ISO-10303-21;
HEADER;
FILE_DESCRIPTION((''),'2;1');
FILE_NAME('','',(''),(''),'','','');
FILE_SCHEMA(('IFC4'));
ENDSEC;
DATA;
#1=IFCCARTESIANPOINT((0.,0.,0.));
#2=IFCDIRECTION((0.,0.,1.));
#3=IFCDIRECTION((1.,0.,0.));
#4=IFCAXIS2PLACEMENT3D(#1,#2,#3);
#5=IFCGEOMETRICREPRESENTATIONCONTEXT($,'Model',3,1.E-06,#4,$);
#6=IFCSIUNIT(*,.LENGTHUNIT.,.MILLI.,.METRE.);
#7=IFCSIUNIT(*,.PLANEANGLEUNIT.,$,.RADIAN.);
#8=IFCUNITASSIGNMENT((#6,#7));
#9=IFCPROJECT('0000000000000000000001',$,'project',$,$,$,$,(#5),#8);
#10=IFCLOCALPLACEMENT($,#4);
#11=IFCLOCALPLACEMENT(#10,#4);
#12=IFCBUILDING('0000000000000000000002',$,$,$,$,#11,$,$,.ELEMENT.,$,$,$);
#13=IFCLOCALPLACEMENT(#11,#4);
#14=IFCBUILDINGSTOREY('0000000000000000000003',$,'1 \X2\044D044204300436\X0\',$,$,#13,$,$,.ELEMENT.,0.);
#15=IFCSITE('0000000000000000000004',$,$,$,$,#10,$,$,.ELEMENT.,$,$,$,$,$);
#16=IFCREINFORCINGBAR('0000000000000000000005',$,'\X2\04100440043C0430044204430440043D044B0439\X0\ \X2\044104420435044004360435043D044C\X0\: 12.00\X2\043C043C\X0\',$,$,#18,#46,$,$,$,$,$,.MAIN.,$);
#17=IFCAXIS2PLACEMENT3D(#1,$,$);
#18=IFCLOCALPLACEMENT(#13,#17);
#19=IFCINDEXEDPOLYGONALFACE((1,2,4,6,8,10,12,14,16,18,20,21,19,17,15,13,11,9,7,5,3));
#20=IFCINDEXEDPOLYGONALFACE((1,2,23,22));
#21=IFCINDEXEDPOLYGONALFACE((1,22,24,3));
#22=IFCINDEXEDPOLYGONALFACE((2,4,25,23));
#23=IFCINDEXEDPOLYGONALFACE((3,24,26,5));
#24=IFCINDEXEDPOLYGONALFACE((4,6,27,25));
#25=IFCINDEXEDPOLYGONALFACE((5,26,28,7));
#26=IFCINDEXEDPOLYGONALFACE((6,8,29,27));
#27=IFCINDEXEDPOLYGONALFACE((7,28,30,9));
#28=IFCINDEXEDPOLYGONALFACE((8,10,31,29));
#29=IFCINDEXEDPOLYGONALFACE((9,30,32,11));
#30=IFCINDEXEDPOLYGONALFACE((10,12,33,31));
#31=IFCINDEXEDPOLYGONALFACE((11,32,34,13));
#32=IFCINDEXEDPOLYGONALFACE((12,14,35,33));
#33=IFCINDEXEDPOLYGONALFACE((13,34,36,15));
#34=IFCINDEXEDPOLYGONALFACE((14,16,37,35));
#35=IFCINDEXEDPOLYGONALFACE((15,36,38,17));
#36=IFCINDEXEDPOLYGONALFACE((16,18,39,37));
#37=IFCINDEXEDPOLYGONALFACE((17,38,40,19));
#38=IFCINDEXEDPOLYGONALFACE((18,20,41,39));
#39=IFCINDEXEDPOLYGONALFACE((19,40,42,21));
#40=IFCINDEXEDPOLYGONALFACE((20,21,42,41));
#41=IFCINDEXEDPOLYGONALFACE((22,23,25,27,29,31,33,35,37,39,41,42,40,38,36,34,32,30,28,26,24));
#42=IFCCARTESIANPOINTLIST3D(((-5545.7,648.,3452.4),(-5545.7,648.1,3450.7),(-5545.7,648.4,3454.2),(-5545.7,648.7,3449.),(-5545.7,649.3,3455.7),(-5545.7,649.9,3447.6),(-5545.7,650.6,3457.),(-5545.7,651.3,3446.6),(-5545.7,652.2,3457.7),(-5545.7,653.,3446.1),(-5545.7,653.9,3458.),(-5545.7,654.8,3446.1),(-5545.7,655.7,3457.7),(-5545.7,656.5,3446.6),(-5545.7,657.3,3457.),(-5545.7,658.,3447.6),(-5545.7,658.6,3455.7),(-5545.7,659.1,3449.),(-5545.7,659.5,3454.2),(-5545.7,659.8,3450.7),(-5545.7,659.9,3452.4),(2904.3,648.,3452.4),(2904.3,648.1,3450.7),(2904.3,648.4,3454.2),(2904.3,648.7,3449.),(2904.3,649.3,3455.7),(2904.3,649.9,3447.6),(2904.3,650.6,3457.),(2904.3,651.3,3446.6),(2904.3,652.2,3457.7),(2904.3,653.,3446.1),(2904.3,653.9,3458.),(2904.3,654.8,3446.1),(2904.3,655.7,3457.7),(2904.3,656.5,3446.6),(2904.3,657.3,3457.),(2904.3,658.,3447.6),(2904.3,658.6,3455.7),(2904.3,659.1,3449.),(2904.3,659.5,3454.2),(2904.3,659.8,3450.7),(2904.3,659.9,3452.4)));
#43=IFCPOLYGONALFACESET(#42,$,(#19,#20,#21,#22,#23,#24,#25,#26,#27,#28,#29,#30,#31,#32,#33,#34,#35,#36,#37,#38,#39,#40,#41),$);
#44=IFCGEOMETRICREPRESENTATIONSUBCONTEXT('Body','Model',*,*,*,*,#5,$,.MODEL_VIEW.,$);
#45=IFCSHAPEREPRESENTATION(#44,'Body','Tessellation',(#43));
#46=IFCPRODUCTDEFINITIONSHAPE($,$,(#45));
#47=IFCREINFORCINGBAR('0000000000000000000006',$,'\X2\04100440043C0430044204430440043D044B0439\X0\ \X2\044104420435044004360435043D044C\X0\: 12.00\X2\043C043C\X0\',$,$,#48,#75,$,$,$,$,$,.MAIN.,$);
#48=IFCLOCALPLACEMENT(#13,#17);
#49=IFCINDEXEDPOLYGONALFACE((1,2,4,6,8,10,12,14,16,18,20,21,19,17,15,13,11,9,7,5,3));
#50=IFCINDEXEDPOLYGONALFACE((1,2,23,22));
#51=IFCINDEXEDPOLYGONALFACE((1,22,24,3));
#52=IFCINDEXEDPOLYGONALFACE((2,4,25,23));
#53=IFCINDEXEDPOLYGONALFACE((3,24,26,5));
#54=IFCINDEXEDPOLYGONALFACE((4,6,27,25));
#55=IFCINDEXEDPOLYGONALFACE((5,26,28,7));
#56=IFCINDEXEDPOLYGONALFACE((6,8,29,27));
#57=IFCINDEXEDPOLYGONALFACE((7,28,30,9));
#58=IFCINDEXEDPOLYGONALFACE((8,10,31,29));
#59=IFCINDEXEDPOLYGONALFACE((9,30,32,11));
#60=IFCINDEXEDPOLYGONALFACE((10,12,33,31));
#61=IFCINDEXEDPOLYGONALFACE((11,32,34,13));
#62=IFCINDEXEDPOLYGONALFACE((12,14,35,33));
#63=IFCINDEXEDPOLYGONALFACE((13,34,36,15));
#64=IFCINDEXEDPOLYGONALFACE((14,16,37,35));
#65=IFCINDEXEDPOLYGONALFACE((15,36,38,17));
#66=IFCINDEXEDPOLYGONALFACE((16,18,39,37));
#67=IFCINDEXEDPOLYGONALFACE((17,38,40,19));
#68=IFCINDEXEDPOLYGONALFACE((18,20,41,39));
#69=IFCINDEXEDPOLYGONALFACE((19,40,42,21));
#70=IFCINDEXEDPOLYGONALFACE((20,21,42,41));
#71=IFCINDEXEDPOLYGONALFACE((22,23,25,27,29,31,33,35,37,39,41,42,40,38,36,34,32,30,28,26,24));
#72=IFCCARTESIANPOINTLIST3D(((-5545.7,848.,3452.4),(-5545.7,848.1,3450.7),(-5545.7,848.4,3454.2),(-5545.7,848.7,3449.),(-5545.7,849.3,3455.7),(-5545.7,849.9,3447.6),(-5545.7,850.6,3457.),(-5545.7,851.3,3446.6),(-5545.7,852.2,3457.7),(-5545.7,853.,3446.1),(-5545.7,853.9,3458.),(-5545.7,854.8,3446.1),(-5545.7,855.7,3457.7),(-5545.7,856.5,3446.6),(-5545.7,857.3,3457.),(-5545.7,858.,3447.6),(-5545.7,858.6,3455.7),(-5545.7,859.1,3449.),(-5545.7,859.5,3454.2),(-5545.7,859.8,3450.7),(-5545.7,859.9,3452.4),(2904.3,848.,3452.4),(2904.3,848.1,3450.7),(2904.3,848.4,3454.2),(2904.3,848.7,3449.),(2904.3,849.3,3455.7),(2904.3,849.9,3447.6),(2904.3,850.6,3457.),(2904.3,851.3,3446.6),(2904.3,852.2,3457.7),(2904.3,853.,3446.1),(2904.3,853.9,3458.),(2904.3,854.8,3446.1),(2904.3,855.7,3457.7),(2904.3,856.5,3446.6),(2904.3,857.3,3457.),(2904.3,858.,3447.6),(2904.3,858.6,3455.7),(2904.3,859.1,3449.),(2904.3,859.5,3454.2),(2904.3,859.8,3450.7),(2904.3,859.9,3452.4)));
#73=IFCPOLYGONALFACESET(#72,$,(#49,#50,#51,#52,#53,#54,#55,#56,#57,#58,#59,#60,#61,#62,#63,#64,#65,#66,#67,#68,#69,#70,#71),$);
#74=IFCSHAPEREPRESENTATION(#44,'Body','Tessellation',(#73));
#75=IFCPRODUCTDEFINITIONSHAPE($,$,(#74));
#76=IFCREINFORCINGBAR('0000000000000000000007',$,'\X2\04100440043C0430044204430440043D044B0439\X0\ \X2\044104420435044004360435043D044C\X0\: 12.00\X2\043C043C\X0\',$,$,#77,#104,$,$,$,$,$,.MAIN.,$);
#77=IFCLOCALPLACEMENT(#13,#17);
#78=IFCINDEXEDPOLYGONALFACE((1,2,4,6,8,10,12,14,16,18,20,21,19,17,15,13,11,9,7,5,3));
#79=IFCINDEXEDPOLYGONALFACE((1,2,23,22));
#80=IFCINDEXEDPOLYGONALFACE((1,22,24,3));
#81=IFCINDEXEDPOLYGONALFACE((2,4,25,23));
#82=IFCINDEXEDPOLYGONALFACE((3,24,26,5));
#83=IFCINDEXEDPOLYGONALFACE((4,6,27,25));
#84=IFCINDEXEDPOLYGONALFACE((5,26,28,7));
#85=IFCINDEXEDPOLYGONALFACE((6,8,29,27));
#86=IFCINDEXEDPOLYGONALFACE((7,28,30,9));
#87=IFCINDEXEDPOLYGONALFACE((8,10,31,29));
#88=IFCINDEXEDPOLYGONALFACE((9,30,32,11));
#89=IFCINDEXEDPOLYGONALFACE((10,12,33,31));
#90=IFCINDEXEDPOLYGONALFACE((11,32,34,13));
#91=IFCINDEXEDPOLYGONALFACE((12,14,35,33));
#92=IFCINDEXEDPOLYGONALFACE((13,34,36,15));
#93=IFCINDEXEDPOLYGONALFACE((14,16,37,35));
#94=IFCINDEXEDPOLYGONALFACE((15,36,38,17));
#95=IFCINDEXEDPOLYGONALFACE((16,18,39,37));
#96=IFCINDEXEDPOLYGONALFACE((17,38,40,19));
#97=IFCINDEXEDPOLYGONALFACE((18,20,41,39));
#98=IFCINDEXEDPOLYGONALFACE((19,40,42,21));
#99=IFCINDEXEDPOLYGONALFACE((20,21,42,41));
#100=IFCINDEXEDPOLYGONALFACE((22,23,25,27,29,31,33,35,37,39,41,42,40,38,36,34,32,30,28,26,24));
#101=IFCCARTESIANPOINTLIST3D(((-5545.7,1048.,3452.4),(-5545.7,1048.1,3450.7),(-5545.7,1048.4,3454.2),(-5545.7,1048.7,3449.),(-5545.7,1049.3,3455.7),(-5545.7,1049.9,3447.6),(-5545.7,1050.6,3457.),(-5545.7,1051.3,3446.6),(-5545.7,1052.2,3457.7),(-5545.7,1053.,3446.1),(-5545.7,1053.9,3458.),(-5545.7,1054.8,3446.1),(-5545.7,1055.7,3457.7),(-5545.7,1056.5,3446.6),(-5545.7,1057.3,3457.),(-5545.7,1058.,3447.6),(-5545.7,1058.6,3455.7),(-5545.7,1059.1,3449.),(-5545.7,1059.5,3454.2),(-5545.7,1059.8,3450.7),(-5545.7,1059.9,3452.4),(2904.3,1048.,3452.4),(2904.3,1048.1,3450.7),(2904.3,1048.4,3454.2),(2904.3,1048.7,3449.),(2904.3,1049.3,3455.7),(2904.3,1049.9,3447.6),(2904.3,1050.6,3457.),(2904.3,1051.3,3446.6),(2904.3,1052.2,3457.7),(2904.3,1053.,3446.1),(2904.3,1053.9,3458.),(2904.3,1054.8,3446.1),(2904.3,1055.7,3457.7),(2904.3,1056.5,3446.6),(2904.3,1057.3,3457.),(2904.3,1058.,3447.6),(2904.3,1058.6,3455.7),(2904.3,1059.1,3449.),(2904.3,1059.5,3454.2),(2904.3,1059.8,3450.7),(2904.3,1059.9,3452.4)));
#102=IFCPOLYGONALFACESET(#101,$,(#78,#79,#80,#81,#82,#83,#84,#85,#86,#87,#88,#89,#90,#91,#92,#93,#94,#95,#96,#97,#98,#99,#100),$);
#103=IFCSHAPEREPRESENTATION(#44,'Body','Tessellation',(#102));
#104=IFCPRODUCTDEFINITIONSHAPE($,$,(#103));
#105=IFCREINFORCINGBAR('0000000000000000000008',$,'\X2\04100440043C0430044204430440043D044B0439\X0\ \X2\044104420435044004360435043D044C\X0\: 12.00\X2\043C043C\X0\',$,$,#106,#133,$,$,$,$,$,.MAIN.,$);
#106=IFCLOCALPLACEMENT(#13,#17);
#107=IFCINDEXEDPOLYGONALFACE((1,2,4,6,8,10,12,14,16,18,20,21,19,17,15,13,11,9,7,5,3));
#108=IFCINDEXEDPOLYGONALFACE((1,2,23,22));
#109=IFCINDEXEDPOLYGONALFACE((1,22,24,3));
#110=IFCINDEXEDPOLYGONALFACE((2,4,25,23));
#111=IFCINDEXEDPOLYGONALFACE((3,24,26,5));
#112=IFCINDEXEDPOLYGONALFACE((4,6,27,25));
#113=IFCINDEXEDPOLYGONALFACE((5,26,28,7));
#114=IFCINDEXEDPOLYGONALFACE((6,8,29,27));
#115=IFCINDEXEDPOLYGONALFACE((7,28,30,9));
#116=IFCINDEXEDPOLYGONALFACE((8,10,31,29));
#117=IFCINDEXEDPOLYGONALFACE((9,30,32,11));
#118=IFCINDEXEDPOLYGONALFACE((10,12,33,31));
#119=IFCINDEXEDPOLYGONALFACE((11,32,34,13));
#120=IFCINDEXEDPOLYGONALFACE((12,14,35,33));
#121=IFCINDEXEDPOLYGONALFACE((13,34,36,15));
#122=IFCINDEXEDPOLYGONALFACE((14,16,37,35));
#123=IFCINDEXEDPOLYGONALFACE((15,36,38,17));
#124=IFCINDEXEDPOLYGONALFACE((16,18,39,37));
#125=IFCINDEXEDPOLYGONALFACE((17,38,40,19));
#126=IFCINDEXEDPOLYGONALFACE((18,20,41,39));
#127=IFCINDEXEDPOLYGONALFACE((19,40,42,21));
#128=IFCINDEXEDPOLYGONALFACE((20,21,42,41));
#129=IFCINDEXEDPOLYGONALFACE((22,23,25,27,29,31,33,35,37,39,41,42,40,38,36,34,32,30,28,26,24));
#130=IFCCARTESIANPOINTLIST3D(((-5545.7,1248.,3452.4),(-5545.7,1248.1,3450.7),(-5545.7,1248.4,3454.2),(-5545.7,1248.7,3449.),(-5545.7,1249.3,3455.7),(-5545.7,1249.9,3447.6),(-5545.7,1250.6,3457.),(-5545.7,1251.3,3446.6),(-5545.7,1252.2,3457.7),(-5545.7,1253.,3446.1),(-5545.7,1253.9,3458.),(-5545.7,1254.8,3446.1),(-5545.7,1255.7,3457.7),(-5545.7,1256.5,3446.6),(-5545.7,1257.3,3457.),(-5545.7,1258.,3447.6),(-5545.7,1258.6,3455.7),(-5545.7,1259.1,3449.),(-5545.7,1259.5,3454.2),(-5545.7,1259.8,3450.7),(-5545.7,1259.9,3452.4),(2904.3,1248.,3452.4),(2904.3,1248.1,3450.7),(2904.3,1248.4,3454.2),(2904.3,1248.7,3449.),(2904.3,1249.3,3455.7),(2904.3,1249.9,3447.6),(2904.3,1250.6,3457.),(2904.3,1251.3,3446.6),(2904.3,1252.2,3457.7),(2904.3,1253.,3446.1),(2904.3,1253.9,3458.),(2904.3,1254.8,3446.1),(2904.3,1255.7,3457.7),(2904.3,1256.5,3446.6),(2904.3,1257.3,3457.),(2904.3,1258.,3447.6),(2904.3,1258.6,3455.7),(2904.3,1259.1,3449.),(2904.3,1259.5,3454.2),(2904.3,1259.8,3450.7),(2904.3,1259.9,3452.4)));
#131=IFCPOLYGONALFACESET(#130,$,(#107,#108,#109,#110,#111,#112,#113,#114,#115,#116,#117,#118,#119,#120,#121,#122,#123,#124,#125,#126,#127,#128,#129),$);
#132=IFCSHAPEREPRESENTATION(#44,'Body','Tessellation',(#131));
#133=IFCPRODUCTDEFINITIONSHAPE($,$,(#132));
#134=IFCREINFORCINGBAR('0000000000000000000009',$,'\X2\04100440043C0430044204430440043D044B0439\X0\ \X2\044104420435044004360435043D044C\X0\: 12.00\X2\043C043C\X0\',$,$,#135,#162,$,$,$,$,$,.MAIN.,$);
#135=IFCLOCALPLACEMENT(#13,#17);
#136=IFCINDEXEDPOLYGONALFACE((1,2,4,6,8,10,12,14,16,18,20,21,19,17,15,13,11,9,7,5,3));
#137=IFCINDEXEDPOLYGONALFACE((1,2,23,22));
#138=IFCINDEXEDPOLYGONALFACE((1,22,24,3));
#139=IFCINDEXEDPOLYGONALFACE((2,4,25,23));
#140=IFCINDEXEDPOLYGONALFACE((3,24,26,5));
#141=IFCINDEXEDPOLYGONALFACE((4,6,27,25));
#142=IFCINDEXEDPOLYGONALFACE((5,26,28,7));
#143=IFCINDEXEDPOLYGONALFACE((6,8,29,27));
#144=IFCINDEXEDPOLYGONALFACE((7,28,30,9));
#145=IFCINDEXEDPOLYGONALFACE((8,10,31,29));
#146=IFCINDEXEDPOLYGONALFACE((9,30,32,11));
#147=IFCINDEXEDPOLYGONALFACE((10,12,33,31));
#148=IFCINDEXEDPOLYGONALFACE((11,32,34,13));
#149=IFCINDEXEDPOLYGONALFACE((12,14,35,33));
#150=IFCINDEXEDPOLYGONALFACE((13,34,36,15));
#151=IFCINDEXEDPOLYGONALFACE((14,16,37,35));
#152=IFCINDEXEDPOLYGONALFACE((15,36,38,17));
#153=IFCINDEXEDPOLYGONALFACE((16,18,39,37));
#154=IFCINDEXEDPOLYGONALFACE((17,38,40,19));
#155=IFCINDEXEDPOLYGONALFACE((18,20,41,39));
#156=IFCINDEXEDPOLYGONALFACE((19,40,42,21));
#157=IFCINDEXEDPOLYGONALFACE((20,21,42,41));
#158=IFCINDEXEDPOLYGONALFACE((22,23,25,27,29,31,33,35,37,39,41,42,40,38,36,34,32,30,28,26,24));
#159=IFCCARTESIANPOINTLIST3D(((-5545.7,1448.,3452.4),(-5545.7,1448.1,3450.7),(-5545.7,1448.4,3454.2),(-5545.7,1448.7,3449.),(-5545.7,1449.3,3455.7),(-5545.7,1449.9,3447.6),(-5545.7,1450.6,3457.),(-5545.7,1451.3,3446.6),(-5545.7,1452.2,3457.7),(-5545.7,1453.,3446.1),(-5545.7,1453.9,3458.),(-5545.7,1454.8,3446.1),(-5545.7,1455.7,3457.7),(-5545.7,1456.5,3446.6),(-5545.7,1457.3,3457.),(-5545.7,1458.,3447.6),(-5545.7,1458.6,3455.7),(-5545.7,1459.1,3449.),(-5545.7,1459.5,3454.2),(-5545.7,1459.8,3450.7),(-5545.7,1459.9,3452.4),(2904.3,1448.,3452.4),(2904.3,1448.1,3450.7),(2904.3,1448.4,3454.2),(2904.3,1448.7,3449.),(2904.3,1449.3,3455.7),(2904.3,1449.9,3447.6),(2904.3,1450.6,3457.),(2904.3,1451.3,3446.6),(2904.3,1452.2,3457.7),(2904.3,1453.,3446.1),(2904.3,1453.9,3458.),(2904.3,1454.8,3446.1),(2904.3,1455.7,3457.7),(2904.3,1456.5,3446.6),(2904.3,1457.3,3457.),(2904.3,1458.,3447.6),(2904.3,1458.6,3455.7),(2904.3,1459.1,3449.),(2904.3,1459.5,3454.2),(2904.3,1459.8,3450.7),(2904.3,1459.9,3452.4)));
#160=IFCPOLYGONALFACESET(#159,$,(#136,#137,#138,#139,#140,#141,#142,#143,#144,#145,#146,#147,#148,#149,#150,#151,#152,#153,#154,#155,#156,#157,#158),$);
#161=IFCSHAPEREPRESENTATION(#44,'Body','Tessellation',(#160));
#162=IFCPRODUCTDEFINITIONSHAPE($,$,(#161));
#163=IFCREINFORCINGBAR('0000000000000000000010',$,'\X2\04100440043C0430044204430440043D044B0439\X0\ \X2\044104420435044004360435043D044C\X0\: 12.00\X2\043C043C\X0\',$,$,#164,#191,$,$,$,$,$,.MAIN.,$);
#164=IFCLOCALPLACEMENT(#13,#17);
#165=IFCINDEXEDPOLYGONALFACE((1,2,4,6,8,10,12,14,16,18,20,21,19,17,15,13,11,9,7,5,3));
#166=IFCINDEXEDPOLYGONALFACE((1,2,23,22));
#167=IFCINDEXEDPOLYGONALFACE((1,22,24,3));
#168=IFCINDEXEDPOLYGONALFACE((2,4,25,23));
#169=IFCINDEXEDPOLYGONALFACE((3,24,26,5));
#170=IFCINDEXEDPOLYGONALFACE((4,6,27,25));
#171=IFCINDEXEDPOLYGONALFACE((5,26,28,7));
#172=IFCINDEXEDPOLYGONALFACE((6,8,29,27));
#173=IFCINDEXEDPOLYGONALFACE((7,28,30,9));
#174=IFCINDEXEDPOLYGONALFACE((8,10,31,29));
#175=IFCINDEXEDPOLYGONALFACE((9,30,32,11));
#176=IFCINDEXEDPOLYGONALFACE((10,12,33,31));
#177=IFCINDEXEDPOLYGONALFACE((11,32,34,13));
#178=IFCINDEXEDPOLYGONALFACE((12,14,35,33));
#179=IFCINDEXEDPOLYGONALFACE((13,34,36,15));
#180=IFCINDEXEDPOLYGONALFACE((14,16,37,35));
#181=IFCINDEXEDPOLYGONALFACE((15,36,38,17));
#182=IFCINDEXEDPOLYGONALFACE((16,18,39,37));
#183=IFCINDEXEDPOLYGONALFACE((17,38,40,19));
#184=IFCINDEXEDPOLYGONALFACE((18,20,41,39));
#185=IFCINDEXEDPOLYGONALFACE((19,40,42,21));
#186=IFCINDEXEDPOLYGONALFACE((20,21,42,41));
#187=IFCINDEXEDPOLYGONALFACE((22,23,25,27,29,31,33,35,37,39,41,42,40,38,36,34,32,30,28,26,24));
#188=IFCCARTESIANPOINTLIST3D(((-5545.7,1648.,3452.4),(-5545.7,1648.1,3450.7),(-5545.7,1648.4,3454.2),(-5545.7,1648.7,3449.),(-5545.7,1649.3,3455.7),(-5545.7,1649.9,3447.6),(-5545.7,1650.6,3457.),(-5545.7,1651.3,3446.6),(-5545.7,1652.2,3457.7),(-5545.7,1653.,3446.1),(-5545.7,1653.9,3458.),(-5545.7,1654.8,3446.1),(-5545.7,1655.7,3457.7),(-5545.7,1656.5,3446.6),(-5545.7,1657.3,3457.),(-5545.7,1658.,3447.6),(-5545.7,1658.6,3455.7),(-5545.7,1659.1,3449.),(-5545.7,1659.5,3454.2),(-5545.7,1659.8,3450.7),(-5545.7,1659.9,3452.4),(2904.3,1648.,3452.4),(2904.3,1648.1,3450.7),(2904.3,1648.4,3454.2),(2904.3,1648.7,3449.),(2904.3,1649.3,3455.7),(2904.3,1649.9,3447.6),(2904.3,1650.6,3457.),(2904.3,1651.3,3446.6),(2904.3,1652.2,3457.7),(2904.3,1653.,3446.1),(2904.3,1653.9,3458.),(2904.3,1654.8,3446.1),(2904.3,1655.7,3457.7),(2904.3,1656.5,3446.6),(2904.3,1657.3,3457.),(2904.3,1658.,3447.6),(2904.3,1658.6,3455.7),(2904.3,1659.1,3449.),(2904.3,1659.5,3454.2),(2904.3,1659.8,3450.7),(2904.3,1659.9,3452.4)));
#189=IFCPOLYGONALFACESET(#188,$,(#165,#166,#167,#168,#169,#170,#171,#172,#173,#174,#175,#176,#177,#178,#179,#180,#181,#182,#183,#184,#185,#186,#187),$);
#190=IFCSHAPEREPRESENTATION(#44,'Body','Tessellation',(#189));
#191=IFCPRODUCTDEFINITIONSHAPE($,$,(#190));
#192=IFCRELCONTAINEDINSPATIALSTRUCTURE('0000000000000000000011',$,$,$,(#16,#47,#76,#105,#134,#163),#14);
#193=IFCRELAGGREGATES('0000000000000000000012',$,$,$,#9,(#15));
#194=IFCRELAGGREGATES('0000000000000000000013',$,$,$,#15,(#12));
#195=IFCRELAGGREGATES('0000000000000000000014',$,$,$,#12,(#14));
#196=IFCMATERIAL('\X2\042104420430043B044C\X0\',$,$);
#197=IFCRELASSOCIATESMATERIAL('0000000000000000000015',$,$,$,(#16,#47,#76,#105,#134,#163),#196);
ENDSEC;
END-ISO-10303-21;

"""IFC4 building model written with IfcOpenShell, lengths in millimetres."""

from ifc_helpers import new_model, entity, si_unit, origin_with_axes, place, context, subcontext, project, spatial, source, transform, mapped, material, element, save


model = new_model("IFC4")

# Units and contexts
model_context = context("Model", 3, precision=1e-06, world=origin_with_axes())
body_context = subcontext(model_context, "Body", "Model", "MODEL_VIEW")
ifc_project = project(units=[si_unit("LENGTHUNIT", "METRE", prefix="MILLI"), si_unit("PLANEANGLEUNIT", "RADIAN")], contexts=[model_context])

# Site, building, storey
site_placement = place(None, origin_with_axes())
site = spatial("IfcSite", under=ifc_project, at=site_placement, CompositionType="ELEMENT")
building_placement = place(site_placement, origin_with_axes())
building = spatial("IfcBuilding", under=site, at=building_placement, CompositionType="ELEMENT")
storey_placement = place(building_placement, origin_with_axes())
storey = spatial("IfcBuildingStorey", under=building, at=storey_placement, Name="1 этаж", CompositionType="ELEMENT", Elevation=0.0)

# Reinforcing bars
ifc_material_1 = material(Name="Сталь")
shared_shape_1 = source(origin_with_axes(), body_context, "Body", "AdvancedSweptSolid", [
    entity("IfcSweptDiskSolid", entity("IfcIndexedPolyCurve", entity("IfcCartesianPointList3D", [[0.0, 0.0, 0.0], [8450.0, 0.0, 0.0]]), [entity("IfcLineIndex", [1, 2])]), 6.0),
])
reinforcing_bar_1_placement = place(storey_placement, origin_with_axes())
element("IfcReinforcingBar", 1, at=reinforcing_bar_1_placement, inside=storey, material=ifc_material_1, Name="Арматурный стержень: 12.00мм", PredefinedType="MAIN", context=body_context, shape_type="MappedRepresentation", body=[
    mapped(shared_shape_1, transform((-5545.7, 653.9, 3452.0), x_axis=(1.0, 0.0, 0.0), y_axis=(0.0, 1.0, 0.0), z_axis=(0.0, 0.0, 1.0), scale=1.0)),
])
reinforcing_bar_2_placement = place(storey_placement, origin_with_axes())
element("IfcReinforcingBar", 2, at=reinforcing_bar_2_placement, inside=storey, material=ifc_material_1, Name="Арматурный стержень: 12.00мм", PredefinedType="MAIN", context=body_context, shape_type="MappedRepresentation", body=[
    mapped(shared_shape_1, transform((-5545.7, 853.9, 3452.0), x_axis=(1.0, 0.0, 0.0), y_axis=(0.0, 1.0, 0.0), z_axis=(0.0, 0.0, 1.0), scale=1.0)),
])
reinforcing_bar_3_placement = place(storey_placement, origin_with_axes())
element("IfcReinforcingBar", 3, at=reinforcing_bar_3_placement, inside=storey, material=ifc_material_1, Name="Арматурный стержень: 12.00мм", PredefinedType="MAIN", context=body_context, shape_type="MappedRepresentation", body=[
    mapped(shared_shape_1, transform((-5545.7, 1053.9, 3452.0), x_axis=(1.0, 0.0, 0.0), y_axis=(0.0, 1.0, 0.0), z_axis=(0.0, 0.0, 1.0), scale=1.0)),
])
reinforcing_bar_4_placement = place(storey_placement, origin_with_axes())
element("IfcReinforcingBar", 4, at=reinforcing_bar_4_placement, inside=storey, material=ifc_material_1, Name="Арматурный стержень: 12.00мм", PredefinedType="MAIN", context=body_context, shape_type="MappedRepresentation", body=[
    mapped(shared_shape_1, transform((-5545.7, 1253.9, 3452.0), x_axis=(1.0, 0.0, 0.0), y_axis=(0.0, 1.0, 0.0), z_axis=(0.0, 0.0, 1.0), scale=1.0)),
])
reinforcing_bar_5_placement = place(storey_placement, origin_with_axes())
element("IfcReinforcingBar", 5, at=reinforcing_bar_5_placement, inside=storey, material=ifc_material_1, Name="Арматурный стержень: 12.00мм", PredefinedType="MAIN", context=body_context, shape_type="MappedRepresentation", body=[
    mapped(shared_shape_1, transform((-5545.7, 1453.9, 3452.0), x_axis=(1.0, 0.0, 0.0), y_axis=(0.0, 1.0, 0.0), z_axis=(0.0, 0.0, 1.0), scale=1.0)),
])
reinforcing_bar_6_placement = place(storey_placement, origin_with_axes())
element("IfcReinforcingBar", 6, at=reinforcing_bar_6_placement, inside=storey, material=ifc_material_1, Name="Арматурный стержень: 12.00мм", PredefinedType="MAIN", context=body_context, shape_type="MappedRepresentation", body=[
    mapped(shared_shape_1, transform((-5545.7, 1653.9, 3452.0), x_axis=(1.0, 0.0, 0.0), y_axis=(0.0, 1.0, 0.0), z_axis=(0.0, 0.0, 1.0), scale=1.0)),
])

save(model, "model.ifc")
